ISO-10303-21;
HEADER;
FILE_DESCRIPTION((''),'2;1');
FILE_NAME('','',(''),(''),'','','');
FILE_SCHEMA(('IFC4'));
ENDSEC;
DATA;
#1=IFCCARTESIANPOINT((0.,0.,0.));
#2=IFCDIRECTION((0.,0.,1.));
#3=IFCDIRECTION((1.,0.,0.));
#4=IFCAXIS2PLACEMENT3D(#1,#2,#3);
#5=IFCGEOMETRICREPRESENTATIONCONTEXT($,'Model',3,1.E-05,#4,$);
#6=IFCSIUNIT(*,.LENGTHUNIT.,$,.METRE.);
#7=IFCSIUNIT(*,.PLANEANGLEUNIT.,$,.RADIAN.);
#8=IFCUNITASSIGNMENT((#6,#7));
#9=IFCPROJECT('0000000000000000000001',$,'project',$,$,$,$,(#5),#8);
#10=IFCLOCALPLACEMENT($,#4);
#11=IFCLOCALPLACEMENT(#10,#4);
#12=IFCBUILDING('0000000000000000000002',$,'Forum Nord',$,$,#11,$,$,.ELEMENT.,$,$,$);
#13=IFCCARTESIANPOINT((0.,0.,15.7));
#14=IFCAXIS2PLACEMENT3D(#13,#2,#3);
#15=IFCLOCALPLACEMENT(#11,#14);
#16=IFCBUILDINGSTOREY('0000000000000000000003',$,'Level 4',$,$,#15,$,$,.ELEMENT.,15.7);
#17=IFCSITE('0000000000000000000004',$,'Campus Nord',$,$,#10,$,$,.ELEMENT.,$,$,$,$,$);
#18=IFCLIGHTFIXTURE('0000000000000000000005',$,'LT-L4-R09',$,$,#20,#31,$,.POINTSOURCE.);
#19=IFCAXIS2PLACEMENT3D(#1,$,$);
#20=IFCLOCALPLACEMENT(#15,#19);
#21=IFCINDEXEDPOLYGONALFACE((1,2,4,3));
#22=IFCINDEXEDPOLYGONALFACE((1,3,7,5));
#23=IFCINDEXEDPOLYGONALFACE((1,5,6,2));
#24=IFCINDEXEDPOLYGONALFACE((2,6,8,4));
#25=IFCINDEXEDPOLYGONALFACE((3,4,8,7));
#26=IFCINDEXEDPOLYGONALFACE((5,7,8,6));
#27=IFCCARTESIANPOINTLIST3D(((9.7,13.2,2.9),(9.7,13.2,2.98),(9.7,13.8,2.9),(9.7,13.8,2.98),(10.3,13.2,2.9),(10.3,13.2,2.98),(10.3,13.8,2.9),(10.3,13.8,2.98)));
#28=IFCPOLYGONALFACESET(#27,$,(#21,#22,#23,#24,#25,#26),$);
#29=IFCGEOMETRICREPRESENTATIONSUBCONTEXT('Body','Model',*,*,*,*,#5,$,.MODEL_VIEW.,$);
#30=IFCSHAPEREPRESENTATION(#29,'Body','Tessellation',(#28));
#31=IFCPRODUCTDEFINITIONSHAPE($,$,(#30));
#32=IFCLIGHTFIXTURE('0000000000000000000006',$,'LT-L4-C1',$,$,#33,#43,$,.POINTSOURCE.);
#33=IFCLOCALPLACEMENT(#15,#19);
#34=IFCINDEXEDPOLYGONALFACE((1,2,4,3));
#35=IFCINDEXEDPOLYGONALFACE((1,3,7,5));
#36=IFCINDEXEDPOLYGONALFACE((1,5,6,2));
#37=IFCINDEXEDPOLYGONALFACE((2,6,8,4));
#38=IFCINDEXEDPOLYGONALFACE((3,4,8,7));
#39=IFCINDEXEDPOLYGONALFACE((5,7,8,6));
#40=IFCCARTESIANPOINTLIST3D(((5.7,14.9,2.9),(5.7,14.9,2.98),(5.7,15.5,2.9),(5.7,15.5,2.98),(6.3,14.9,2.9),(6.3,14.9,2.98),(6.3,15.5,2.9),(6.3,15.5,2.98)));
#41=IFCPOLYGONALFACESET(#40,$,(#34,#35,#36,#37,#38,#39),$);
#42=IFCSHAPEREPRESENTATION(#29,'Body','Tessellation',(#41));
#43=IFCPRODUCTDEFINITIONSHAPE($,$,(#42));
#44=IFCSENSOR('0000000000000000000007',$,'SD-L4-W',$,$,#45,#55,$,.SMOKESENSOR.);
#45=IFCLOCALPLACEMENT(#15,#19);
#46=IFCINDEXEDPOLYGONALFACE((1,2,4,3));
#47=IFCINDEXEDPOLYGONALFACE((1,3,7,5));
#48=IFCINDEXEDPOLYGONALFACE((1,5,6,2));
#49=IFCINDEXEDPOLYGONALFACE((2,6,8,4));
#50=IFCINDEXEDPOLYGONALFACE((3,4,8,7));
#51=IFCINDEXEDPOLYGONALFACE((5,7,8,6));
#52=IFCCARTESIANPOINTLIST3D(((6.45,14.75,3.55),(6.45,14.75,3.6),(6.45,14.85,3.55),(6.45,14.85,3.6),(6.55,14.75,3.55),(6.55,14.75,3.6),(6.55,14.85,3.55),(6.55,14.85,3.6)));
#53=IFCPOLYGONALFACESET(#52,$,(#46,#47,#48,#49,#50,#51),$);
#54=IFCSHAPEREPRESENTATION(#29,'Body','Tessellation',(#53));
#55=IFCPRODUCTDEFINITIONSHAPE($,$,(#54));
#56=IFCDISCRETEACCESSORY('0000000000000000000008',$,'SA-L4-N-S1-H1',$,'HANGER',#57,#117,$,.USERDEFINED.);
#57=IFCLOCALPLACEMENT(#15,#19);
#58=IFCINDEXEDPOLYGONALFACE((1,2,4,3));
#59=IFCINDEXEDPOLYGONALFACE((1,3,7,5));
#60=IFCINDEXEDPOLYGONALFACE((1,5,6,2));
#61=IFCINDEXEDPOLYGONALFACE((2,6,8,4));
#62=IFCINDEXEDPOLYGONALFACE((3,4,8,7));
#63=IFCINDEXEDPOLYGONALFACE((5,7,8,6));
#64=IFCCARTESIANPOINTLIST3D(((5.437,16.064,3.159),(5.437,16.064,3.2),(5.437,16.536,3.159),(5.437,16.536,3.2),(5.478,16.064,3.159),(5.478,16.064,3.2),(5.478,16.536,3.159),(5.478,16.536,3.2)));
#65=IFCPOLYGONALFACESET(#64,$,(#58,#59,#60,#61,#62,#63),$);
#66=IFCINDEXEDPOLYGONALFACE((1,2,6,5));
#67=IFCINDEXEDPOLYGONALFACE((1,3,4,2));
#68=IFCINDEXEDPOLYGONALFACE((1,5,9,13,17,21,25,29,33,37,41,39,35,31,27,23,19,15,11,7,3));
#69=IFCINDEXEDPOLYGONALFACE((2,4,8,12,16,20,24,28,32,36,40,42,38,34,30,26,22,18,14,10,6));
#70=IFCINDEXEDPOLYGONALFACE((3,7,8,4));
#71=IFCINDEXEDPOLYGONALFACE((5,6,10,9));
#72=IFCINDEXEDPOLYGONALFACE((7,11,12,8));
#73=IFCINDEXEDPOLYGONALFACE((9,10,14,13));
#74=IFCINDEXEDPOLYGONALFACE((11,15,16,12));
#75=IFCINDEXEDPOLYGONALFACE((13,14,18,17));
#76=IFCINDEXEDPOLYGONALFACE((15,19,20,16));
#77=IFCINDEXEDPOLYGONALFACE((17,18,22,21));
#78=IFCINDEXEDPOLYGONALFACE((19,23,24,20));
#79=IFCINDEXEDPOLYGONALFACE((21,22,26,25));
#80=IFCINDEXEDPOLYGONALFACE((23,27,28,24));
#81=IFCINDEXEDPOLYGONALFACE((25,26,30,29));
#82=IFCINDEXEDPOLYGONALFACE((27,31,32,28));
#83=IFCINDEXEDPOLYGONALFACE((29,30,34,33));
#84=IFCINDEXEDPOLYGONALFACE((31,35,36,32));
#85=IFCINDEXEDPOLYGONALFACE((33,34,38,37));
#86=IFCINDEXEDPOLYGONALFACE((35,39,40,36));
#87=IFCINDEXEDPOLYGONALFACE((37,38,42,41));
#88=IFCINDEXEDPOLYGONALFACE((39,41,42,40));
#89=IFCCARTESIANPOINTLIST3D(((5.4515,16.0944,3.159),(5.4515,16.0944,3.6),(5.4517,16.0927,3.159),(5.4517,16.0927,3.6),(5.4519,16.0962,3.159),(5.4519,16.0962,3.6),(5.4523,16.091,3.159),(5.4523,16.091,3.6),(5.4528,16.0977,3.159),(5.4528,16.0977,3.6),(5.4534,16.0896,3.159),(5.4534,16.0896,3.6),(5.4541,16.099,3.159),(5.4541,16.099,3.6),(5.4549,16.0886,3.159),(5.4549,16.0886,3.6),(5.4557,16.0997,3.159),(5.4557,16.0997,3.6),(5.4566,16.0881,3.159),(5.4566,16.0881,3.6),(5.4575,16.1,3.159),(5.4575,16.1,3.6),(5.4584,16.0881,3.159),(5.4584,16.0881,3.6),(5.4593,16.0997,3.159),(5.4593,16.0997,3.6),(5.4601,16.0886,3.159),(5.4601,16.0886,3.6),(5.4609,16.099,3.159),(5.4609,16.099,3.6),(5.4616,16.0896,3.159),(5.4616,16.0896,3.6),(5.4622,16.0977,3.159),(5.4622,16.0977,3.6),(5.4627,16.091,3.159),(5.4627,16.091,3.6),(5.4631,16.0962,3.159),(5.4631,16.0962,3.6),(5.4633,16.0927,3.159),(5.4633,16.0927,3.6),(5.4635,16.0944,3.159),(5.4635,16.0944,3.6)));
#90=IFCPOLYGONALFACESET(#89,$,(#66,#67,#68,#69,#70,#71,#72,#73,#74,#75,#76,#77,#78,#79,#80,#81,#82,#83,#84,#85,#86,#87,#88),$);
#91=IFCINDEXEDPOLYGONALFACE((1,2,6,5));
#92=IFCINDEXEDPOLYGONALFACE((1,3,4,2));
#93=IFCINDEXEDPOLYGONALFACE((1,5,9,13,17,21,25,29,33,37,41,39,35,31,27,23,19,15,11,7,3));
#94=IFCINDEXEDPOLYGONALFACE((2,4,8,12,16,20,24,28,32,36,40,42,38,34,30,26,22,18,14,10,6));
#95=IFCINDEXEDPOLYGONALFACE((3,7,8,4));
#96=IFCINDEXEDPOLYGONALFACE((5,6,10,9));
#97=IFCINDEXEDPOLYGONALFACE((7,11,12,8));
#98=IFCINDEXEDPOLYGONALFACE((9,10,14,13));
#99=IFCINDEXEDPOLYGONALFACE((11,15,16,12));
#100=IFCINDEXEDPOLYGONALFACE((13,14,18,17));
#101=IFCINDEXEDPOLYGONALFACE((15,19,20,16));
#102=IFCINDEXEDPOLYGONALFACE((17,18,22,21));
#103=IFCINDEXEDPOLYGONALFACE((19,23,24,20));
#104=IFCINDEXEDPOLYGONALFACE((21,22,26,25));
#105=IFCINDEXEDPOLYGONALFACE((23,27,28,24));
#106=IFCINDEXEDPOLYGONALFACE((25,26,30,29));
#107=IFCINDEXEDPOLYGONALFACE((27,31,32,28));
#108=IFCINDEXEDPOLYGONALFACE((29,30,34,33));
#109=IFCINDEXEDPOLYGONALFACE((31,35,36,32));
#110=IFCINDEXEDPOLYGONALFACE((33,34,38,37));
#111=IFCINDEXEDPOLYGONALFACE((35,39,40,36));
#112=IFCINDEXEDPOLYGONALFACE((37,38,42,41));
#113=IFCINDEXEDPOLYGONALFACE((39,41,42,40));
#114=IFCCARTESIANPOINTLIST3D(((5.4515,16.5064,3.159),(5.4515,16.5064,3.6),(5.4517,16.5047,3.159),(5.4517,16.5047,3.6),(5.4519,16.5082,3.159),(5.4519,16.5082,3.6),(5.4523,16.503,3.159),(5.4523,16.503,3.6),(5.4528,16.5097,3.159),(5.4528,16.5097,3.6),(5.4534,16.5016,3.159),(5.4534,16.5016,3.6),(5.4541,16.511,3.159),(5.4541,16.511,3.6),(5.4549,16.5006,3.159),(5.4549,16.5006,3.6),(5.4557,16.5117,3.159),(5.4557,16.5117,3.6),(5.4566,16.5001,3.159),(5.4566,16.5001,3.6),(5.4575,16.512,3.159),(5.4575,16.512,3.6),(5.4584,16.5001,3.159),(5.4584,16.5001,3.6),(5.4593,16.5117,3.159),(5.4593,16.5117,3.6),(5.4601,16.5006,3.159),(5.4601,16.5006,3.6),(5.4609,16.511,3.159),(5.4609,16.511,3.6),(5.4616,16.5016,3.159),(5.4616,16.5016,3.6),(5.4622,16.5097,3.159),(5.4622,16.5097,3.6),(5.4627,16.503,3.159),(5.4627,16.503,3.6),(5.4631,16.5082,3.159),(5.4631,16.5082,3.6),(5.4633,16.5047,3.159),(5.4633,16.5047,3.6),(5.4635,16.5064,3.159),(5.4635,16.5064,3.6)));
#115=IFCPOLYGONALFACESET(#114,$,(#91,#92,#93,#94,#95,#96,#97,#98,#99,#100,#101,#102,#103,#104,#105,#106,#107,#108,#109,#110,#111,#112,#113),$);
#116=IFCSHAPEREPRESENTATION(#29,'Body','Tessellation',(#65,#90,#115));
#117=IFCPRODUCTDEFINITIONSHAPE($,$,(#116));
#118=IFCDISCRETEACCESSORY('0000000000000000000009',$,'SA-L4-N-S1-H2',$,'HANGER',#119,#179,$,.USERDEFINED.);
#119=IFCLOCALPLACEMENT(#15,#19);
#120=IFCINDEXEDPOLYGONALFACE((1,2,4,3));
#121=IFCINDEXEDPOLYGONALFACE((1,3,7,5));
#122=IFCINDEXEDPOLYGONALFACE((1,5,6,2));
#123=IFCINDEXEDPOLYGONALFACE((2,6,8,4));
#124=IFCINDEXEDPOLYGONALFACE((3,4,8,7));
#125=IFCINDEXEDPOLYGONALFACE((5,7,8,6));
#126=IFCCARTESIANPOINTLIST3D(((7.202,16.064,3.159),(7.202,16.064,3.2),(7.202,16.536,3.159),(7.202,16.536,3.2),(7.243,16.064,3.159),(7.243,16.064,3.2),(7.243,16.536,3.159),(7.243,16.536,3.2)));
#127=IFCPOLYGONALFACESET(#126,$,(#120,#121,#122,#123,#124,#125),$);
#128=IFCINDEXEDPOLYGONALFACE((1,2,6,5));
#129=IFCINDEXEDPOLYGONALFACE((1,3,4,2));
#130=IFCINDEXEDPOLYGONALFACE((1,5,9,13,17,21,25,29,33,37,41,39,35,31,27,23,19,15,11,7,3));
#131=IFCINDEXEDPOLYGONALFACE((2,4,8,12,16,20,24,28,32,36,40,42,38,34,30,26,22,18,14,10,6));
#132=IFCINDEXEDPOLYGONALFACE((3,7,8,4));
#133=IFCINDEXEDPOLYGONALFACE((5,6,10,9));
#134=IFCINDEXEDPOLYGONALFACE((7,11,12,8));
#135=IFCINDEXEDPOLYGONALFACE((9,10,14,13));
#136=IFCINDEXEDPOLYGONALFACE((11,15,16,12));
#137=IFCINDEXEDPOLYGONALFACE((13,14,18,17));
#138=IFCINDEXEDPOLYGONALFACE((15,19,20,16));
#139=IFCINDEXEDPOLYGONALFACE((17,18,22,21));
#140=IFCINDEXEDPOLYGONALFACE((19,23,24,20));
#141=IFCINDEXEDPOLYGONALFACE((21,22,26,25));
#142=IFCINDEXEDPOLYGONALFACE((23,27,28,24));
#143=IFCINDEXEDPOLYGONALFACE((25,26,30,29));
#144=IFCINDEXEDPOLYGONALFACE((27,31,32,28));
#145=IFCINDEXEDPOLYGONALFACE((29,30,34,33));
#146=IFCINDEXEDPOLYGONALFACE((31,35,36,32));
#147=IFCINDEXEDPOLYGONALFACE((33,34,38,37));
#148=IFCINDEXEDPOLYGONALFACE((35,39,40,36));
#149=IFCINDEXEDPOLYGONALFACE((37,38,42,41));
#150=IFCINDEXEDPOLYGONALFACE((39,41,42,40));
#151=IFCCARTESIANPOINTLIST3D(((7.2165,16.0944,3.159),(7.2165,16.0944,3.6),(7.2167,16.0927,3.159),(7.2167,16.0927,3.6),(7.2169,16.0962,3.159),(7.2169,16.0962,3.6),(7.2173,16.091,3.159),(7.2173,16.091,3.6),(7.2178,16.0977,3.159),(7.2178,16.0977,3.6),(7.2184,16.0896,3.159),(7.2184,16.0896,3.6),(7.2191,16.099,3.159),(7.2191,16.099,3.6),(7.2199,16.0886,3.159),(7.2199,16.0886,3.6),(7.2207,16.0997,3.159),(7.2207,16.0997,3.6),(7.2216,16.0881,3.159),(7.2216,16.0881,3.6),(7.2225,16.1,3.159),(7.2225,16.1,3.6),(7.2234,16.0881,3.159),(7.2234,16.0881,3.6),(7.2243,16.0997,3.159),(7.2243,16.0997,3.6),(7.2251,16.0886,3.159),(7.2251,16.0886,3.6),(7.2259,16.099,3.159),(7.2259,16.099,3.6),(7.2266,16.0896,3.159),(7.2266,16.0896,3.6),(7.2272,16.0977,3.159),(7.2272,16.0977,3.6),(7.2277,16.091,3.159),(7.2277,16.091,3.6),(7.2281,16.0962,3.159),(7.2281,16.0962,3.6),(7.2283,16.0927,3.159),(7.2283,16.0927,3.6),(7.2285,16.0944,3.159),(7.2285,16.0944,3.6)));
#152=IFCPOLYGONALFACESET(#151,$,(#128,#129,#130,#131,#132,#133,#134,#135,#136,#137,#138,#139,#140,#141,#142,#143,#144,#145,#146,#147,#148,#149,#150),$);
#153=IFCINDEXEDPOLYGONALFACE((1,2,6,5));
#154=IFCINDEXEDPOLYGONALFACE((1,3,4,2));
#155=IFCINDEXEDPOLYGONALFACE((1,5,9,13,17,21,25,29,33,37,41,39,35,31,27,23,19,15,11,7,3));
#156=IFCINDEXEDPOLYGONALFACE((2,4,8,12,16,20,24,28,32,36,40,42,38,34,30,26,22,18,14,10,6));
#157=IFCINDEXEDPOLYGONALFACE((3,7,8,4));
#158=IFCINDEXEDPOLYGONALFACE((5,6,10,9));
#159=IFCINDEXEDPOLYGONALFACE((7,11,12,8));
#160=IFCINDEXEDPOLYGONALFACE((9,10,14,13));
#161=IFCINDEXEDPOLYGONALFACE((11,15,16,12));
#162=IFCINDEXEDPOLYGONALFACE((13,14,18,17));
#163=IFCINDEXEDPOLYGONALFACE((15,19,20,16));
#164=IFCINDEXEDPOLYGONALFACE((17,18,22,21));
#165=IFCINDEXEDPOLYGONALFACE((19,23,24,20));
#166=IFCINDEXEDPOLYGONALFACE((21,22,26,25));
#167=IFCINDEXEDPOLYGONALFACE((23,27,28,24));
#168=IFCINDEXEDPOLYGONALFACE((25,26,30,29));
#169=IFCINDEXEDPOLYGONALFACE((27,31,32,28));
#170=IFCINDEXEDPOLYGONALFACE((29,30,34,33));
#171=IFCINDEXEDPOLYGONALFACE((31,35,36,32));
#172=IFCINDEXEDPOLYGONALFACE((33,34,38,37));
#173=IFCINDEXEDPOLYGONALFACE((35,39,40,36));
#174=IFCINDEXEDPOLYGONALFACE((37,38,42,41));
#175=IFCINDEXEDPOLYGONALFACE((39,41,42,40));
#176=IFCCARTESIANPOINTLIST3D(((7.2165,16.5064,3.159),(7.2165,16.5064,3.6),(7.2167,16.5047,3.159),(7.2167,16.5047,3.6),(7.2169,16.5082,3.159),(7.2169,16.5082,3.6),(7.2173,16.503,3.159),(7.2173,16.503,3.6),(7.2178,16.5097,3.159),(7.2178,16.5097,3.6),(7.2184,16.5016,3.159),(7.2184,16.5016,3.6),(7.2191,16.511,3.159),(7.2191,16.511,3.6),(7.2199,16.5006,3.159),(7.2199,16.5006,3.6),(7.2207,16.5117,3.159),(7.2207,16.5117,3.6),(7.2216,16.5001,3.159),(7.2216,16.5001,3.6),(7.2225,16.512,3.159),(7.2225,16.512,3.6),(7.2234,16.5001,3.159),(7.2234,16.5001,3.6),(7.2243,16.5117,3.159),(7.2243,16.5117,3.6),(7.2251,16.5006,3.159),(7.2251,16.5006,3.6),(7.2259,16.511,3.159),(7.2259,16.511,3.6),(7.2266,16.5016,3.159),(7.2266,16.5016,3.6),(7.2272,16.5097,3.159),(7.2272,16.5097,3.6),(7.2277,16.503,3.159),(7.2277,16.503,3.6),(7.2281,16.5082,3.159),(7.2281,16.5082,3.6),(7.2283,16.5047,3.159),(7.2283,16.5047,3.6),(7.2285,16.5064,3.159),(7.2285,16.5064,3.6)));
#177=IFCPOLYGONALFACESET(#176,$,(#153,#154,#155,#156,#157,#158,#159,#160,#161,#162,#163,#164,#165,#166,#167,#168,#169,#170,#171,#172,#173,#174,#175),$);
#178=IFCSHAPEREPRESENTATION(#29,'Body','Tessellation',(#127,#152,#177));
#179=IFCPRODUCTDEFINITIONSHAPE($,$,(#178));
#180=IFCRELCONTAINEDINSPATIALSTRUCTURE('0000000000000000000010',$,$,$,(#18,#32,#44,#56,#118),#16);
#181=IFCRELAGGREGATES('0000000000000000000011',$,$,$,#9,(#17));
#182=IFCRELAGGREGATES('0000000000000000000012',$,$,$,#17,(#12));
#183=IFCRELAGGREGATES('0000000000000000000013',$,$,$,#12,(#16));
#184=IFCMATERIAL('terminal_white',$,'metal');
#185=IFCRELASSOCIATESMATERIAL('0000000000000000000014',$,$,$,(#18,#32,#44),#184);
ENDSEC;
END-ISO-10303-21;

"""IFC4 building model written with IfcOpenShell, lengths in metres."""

from ifc_helpers import new_model, si_unit, frame, frame_2d, origin_with_axes, origin_2d_with_axis, place, context, subcontext, project, spatial, rectangle, circle, extrude, material, element, save


model = new_model("IFC4")

# Units and contexts
model_context = context("Model", 3, precision=1e-05, world=origin_with_axes())
body_context = subcontext(model_context, "Body", "Model", "MODEL_VIEW")
ifc_project = project(units=[si_unit("LENGTHUNIT", "METRE"), si_unit("PLANEANGLEUNIT", "RADIAN")], contexts=[model_context])

# Site, building, storey
site_placement = place(None, origin_with_axes())
site = spatial("IfcSite", under=ifc_project, at=site_placement, Name="Campus Nord", CompositionType="ELEMENT")
building_placement = place(site_placement, origin_with_axes())
building = spatial("IfcBuilding", under=site, at=building_placement, Name="Forum Nord", CompositionType="ELEMENT")
storey_placement = place(building_placement, frame((0.0, 0.0, 15.7), z_axis=(0.0, 0.0, 1.0), x_axis=(1.0, 0.0, 0.0)))
storey = spatial("IfcBuildingStorey", under=building, at=storey_placement, Name="Level 4", CompositionType="ELEMENT", Elevation=15.7)

# Shared definitions
ifc_material_1 = material(Name="terminal_white", Category="metal")

# Light fixtures
for number, where, z_axis, x_axis, name in (
    (1, (10.0, 13.5, 2.9), (0.0, 0.0, 1.0), (1.0, 0.0, 0.0), "LT-L4-R09"),
    (2, (6.0, 15.2, 2.9), (0.0, 0.0, 1.0), (1.0, 0.0, 0.0), "LT-L4-C1"),
):
    element("IfcLightFixture", number, at=place(storey_placement, frame(where, z_axis=z_axis, x_axis=x_axis)), inside=storey, material=ifc_material_1, Name=name, PredefinedType="POINTSOURCE", context=body_context, shape_type="SweptSolid", body=[
        extrude(rectangle(XDim=0.6, YDim=0.6, at=origin_2d_with_axis()), origin_with_axes(), (0.0, 0.0, 1.0), 0.08),
    ])

# Sensor
sensor_placement = place(storey_placement, frame((6.5, 14.8, 3.55), z_axis=(0.0, 0.0, 1.0), x_axis=(1.0, 0.0, 0.0)))
element("IfcSensor", 3, at=sensor_placement, inside=storey, material=ifc_material_1, Name="SD-L4-W", PredefinedType="SMOKESENSOR", context=body_context, shape_type="SweptSolid", body=[
    extrude(rectangle(XDim=0.1, YDim=0.1, at=origin_2d_with_axis()), origin_with_axes(), (0.0, 0.0, 1.0), 0.05),
])

# Discrete accessories
for number, where, z_axis, x_axis, name in (
    (4, (5.4575, 16.3, 3.2), (0.0, 0.0, 1.0), (0.0, 1.0, 0.0), "SA-L4-N-S1-H1"),
    (5, (7.2225, 16.3, 3.2), (0.0, 0.0, 1.0), (0.0, 1.0, 0.0), "SA-L4-N-S1-H2"),
):
    element("IfcDiscreteAccessory", number, at=place(storey_placement, frame(where, z_axis=z_axis, x_axis=x_axis)), inside=storey, Name=name, ObjectType="HANGER", PredefinedType="USERDEFINED", context=body_context, shape_type="SweptSolid", body=[
        extrude(rectangle(XDim=0.472, YDim=0.041, at=origin_2d_with_axis()), frame((0.0, 0.0, -0.041), z_axis=(0.0, 0.0, 1.0), x_axis=(1.0, 0.0, 0.0)), (0.0, 0.0, 1.0), 0.041),
        extrude(circle(Radius=0.006, at=frame_2d((-0.206, 0.0), x_axis=(1.0, 0.0))), frame((0.0, 0.0, -0.041), z_axis=(0.0, 0.0, 1.0), x_axis=(1.0, 0.0, 0.0)), (0.0, 0.0, 1.0), 0.441),
        extrude(circle(Radius=0.006, at=frame_2d((0.206, 0.0), x_axis=(1.0, 0.0))), frame((0.0, 0.0, -0.041), z_axis=(0.0, 0.0, 1.0), x_axis=(1.0, 0.0, 0.0)), (0.0, 0.0, 1.0), 0.441),
    ])

save(model, "model.ifc")
